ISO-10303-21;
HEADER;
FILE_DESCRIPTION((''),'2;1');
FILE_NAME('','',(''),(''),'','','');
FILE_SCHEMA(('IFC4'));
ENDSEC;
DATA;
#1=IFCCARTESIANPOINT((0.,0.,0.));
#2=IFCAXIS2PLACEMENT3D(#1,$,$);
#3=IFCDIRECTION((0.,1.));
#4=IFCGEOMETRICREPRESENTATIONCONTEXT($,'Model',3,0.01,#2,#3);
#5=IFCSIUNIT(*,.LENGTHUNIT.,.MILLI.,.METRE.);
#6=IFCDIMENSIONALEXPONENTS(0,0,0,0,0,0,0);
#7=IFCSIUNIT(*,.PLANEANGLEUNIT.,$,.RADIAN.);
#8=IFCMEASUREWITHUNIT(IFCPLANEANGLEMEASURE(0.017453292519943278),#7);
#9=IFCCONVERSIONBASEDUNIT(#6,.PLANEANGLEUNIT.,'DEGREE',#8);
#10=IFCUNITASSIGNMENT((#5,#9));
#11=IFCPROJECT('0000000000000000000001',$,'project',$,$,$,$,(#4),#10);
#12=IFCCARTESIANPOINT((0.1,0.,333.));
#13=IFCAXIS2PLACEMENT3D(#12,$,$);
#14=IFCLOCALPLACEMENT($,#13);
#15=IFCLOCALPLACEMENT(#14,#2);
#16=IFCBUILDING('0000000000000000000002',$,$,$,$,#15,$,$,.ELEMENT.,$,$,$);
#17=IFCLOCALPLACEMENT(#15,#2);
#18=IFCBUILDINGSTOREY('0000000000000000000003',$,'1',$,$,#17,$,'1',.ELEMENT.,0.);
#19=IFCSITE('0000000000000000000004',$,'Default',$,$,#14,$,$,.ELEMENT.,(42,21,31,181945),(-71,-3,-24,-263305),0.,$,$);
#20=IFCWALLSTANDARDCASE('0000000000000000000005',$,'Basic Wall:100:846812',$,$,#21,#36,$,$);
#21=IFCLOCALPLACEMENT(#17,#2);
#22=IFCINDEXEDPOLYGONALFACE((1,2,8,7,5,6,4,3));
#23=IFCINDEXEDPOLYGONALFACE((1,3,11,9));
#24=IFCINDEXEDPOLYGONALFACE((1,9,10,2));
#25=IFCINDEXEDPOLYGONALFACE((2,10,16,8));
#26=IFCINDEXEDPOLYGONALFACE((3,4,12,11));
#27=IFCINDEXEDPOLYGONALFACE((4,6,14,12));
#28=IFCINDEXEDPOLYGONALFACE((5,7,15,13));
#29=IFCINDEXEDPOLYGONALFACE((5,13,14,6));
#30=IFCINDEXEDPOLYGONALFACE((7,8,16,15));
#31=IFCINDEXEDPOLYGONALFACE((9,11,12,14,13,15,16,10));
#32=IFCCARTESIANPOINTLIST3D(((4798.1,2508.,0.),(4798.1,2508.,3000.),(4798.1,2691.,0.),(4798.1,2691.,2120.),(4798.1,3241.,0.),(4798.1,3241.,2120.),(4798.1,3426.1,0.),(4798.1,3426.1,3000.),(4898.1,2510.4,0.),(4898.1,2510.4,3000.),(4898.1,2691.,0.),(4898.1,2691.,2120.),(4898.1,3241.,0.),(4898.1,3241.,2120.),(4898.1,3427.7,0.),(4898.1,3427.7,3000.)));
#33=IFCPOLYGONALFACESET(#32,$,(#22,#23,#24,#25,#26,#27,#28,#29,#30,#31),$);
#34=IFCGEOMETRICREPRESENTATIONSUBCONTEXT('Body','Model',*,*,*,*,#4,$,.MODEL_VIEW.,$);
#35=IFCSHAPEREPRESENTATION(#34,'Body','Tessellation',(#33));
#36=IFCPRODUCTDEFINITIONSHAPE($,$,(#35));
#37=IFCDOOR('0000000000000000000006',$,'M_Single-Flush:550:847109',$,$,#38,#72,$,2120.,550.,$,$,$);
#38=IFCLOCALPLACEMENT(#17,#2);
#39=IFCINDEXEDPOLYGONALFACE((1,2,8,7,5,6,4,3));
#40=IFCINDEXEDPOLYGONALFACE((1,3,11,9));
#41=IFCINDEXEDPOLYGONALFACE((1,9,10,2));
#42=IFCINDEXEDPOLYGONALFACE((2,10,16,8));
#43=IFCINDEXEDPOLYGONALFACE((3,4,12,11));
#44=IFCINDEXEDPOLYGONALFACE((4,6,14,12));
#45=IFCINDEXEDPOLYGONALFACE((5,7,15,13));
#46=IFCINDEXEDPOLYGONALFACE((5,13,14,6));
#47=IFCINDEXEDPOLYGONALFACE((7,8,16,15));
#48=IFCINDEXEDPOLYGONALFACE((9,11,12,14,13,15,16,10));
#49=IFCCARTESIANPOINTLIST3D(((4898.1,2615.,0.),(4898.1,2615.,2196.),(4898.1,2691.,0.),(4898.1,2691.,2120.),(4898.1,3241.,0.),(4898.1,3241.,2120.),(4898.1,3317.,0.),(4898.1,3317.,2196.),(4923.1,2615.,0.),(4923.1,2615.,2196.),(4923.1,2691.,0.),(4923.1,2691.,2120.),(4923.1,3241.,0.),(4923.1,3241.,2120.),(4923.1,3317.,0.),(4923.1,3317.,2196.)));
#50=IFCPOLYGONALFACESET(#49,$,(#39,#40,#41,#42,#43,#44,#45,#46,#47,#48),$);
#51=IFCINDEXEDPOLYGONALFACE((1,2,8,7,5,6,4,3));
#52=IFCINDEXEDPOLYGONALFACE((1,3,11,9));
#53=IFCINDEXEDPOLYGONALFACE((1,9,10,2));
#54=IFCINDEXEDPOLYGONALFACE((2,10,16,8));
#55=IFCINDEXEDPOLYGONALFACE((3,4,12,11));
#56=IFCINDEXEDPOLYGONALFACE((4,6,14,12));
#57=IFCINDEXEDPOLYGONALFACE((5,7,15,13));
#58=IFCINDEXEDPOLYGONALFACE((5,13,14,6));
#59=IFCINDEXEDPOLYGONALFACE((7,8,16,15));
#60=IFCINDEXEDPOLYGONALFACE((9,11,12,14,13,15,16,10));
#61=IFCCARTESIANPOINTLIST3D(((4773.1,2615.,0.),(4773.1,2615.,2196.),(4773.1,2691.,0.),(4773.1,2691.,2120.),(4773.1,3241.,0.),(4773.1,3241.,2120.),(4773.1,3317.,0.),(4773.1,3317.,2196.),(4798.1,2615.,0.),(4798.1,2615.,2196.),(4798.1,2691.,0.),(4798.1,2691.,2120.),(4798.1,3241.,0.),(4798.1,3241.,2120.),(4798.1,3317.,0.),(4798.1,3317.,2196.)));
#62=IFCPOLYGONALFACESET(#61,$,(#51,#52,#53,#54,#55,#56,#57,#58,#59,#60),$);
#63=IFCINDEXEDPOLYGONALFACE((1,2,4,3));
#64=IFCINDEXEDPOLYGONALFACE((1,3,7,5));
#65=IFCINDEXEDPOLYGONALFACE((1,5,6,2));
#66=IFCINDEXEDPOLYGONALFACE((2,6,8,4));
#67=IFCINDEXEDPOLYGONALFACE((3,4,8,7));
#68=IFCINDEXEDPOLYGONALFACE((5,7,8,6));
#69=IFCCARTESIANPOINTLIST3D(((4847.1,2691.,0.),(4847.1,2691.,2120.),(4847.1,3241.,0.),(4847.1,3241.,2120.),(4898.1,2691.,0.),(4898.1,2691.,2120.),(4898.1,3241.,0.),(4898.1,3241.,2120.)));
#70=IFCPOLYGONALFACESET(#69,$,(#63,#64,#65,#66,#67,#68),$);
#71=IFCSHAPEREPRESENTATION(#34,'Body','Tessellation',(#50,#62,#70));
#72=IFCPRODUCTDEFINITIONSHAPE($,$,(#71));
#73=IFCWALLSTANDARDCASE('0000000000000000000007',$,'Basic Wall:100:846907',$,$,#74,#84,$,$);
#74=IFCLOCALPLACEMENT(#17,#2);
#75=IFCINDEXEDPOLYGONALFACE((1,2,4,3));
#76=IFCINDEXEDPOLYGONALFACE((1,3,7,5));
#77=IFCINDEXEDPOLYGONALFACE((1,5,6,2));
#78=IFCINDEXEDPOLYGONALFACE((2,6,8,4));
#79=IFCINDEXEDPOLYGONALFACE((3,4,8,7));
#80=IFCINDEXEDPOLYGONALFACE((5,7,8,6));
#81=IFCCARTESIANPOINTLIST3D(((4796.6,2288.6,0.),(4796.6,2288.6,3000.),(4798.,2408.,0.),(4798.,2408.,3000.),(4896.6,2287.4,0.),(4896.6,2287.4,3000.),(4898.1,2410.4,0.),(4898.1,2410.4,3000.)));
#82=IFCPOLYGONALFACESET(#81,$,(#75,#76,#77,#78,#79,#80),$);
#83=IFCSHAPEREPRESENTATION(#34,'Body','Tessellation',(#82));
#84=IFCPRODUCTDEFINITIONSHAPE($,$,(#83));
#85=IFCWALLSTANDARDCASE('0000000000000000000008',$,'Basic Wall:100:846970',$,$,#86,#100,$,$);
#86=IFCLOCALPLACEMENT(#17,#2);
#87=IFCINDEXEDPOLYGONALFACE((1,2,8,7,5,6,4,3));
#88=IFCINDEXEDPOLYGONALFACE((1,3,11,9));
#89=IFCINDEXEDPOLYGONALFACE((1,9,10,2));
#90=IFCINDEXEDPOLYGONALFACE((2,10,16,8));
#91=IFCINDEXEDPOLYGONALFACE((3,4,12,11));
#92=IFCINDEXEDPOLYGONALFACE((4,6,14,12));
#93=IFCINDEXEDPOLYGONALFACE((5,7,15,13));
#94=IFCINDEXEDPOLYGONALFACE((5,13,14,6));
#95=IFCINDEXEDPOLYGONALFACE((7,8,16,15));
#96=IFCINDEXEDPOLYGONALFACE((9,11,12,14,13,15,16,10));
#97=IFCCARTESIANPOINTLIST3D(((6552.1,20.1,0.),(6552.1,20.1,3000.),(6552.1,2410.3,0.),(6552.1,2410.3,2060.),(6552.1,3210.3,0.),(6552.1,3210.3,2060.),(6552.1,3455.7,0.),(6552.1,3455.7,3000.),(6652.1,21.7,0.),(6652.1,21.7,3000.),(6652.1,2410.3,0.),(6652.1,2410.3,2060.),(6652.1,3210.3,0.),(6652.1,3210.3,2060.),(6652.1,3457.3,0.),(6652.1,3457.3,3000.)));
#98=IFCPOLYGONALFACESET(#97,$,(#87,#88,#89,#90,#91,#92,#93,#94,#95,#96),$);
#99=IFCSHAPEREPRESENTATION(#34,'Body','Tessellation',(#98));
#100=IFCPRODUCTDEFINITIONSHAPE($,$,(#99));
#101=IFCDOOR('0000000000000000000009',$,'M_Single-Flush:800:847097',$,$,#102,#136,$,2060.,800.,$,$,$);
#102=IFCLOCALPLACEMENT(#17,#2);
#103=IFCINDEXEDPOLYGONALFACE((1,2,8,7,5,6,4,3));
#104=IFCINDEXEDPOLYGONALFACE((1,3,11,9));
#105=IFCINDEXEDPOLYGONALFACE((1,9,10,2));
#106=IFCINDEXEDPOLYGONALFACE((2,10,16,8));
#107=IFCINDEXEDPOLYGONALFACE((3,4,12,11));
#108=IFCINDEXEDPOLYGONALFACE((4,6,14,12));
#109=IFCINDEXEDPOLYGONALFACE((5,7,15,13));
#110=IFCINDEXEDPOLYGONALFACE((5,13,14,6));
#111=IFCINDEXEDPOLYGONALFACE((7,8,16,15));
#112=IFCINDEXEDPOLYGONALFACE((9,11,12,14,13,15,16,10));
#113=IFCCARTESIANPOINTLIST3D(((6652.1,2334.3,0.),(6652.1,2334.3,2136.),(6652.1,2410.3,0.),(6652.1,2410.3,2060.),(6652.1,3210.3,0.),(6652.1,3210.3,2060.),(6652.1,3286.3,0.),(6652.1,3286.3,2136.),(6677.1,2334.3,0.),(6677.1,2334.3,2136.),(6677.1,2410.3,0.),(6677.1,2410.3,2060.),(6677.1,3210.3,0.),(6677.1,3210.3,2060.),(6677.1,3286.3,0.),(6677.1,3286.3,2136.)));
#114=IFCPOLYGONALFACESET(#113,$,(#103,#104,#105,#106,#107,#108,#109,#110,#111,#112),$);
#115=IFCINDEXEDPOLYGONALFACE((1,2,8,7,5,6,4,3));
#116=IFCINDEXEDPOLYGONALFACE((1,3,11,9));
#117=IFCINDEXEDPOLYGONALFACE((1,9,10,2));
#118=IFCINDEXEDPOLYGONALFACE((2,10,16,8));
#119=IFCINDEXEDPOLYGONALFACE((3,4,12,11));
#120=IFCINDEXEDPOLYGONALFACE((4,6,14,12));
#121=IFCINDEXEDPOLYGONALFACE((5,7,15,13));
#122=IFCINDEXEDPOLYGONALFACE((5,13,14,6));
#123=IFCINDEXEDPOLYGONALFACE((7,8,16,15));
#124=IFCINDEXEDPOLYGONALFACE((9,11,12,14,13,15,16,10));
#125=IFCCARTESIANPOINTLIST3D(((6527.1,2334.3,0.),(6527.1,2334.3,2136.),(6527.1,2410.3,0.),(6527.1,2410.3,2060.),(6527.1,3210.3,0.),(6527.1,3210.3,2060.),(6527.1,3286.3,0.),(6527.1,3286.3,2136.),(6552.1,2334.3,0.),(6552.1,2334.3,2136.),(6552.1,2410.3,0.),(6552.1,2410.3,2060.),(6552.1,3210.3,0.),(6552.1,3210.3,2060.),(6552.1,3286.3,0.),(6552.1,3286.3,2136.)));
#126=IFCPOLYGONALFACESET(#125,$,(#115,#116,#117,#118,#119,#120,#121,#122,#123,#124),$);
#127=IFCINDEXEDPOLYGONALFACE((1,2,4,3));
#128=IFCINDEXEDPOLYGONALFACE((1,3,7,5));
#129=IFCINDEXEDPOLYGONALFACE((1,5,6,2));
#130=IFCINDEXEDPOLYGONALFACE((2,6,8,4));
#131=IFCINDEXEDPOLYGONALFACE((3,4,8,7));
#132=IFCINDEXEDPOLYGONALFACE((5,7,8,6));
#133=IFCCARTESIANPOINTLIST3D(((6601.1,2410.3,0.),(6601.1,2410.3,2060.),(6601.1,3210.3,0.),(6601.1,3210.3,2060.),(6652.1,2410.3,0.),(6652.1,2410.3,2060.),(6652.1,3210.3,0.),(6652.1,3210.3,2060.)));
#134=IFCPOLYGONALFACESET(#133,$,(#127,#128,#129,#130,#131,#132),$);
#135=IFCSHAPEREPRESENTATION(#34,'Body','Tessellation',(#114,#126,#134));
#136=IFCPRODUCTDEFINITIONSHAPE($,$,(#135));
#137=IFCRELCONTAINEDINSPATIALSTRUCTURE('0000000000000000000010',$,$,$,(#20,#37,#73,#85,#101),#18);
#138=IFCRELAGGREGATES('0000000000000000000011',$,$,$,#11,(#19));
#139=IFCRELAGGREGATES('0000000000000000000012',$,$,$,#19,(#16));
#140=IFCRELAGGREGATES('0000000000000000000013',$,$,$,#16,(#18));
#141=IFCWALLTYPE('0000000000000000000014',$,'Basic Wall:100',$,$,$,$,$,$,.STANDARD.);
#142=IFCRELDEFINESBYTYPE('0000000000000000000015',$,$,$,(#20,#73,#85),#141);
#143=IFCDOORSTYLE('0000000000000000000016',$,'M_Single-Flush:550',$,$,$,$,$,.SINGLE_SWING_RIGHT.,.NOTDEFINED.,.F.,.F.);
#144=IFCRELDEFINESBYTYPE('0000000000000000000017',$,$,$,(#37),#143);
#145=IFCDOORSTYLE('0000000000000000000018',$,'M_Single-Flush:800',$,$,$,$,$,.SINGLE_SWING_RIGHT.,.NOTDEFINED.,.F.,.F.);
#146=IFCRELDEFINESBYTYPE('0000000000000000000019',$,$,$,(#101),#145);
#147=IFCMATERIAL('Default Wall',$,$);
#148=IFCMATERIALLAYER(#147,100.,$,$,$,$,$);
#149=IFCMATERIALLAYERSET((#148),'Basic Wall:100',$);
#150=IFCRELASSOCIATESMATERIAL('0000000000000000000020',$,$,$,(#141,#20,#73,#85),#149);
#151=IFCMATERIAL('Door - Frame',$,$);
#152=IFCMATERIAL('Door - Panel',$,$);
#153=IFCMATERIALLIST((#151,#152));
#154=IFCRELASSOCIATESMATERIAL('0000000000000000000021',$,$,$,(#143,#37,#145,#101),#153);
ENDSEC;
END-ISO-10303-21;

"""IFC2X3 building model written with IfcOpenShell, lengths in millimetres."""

from ifc_helpers import new_model, entity, si_unit, converted_unit, direction, frame, frame_2d, origin, origin_2d_with_axis, place, context, subcontext, project, spatial, polyline, rectangle, outline, extrude, source, transform, mapped, material, material_list, layer, layer_set, layer_usage, type_object, type_shapes, element, fill, save


model = new_model("IFC2X3")

# Units and contexts
model_context = context("Model", 3, precision=0.01, world=origin(), true_north=direction((0.0, 1.0)))
body_context = subcontext(model_context, "Body", "Model", "MODEL_VIEW")
ifc_project = project(units=[si_unit("LENGTHUNIT", "METRE", prefix="MILLI"), converted_unit("PLANEANGLEUNIT", "DEGREE", entity("IfcPlaneAngleMeasure", 0.017453292519943278), si_unit("PLANEANGLEUNIT", "RADIAN"), dimensions=[0, 0, 0, 0, 0, 0, 0])], contexts=[model_context])

# Site, building, storey
site_placement = place(None, frame((0.1, 0.0, 333.0)))
site = spatial("IfcSite", under=ifc_project, at=site_placement, Name="Default", CompositionType="ELEMENT", RefLatitude=(42, 21, 31, 181945), RefLongitude=(-71, -3, -24, -263305), RefElevation=0.0)
building_placement = place(site_placement, origin())
building = spatial("IfcBuilding", under=site, at=building_placement, CompositionType="ELEMENT")
storey_placement = place(building_placement, origin())
storey = spatial("IfcBuildingStorey", under=building, at=storey_placement, Name="1", LongName="1", CompositionType="ELEMENT", Elevation=0.0)

# Shared definitions
ifc_material_1 = material(Name="Default Wall")

# Shared definitions
ifc_material_2 = material(Name="Door - Frame")
ifc_material_3 = material(Name="Door - Panel")
ifc_material_list_1 = material_list([ifc_material_2, ifc_material_3])

# Wall, opening, door
ifc_layer_1 = layer(ifc_material_1, 100.0)
ifc_layer_set_1 = layer_set([ifc_layer_1], Name="Basic Wall:100")
ifc_layer_usage_1 = layer_usage(ifc_layer_set_1, "AXIS2", "NEGATIVE", 50.0)
wall_type_1 = type_object("IfcWallType", Name="Basic Wall:100", PredefinedType="STANDARD", material=ifc_layer_set_1)
wall_1_placement = place(storey_placement, frame((4848.1, 2508.0, 0.0), z_axis=(0.0, 0.0, 1.0), x_axis=(0.0, 1.0, 0.0)))
wall_1 = element("IfcWallStandardCase", 1, at=wall_1_placement, inside=storey, type_object=wall_type_1, material=ifc_layer_usage_1, Name="Basic Wall:100:846812", context=body_context, shape_type="SweptSolid", body=[
    extrude(outline(polyline([(2.3, -50.0), (919.7, -50.0), (918.0, 50.0), (0.0, 50.0), (2.3, -50.0)])), origin(), (0.0, 0.0, 1.0), 3000.0),
])
opening_1_placement = place(wall_1_placement, frame((732.9, 50.0, 0.0)))
opening_1 = element("IfcOpeningElement", 2, at=opening_1_placement, cuts=wall_1, ObjectType="Opening", context=body_context, shape_type="SweptSolid", body=[
    extrude(rectangle(XDim=550.0, YDim=2120.0, at=frame_2d((1060.0, 275.0), x_axis=(0.0, 1.0))), frame((0.0, 0.0, 0.0), z_axis=(0.0, -1.0, 0.0), x_axis=(0.0, 0.0, 1.0)), (0.0, 0.0, 1.0), 100.0),
])
door_style_1 = type_object("IfcDoorStyle", Name="M_Single-Flush:550", ConstructionType="NOTDEFINED", OperationType="SINGLE_SWING_RIGHT", ParameterTakesPrecedence=False, Sizeable=False, material=ifc_material_list_1)
shared_shape_1 = source(origin(), body_context, "Body", "SweptSolid", [
    extrude(outline(polyline([(-351.0, -1117.0), (351.0, -1117.0), (351.0, 1079.0), (275.0, 1079.0), (275.0, -1041.0), (-275.0, -1041.0), (-275.0, 1079.0), (-351.0, 1079.0), (-351.0, -1117.0)])), frame((275.0, 100.0, 1079.0), z_axis=(0.0, 1.0, 0.0), x_axis=(1.0, 0.0, 0.0)), (0.0, 0.0, 1.0), 25.0),
    extrude(outline(polyline([(-1117.0, -351.0), (1079.0, -351.0), (1079.0, -275.0), (-1041.0, -275.0), (-1041.0, 275.0), (1079.0, 275.0), (1079.0, 351.0), (-1117.0, 351.0), (-1117.0, -351.0)])), frame((275.0, -25.0, 1079.0), z_axis=(0.0, 1.0, 0.0), x_axis=(0.0, 0.0, -1.0)), (0.0, 0.0, 1.0), 25.0),
    extrude(rectangle(XDim=51.0, YDim=550.0, at=origin_2d_with_axis()), frame((275.0, 74.5, 0.0), z_axis=(0.0, 0.0, 1.0), x_axis=(0.0, 1.0, 0.0)), (0.0, 0.0, 1.0), 2120.0),
])
type_shapes(door_style_1, [shared_shape_1])
door_1_placement = place(opening_1_placement, frame((0.0, 0.0, 0.0), z_axis=(0.0, 0.0, 1.0), x_axis=(-1.0, 0.0, 0.0)))
door_1 = element("IfcDoor", 3, at=door_1_placement, inside=storey, type_object=door_style_1, material=ifc_material_list_1, Name="M_Single-Flush:550:847109", OverallHeight=2120.0, OverallWidth=550.0, context=body_context, shape_type="MappedRepresentation", body=[
    mapped(shared_shape_1, transform((0.0, 0.0, 0.0), scale=1.0)),
])
fill(opening_1, door_1)

# Wall
ifc_layer_usage_2 = layer_usage(ifc_layer_set_1, "AXIS2", "POSITIVE", -50.0)
wall_2_placement = place(storey_placement, frame((4848.1, 2411.0, 0.0), z_axis=(0.0, 0.0, 1.0), x_axis=(-0.011924, -0.999929, 0.0)))
element("IfcWallStandardCase", 4, at=wall_2_placement, inside=storey, type_object=wall_type_1, material=ifc_layer_usage_2, Name="Basic Wall:100:846907", context=body_context, shape_type="SweptSolid", body=[
    extrude(outline(polyline([(122.9, -50.0), (122.9, 50.0), (0.0, 50.0), (3.5, -50.0), (122.9, -50.0)])), origin(), (0.0, 0.0, 1.0), 3000.0),
])

# Wall, opening, door
ifc_layer_usage_3 = layer_usage(ifc_layer_set_1, "AXIS2", "POSITIVE", -50.0)
wall_3_placement = place(storey_placement, frame((6602.1, 3457.3, 0.0), z_axis=(0.0, 0.0, 1.0), x_axis=(0.0, -1.0, 0.0)))
wall_3 = element("IfcWallStandardCase", 5, at=wall_3_placement, inside=storey, type_object=wall_type_1, material=ifc_layer_usage_3, Name="Basic Wall:100:846970", context=body_context, shape_type="SweptSolid", body=[
    extrude(outline(polyline([(1.7, -50.0), (1899.0, -50.0), (1999.0, -50.0), (3437.2, -50.0), (3435.7, 50.0), (3036.9, 50.0), (2936.9, 50.0), (0.0, 50.0), (1.7, -50.0)])), origin(), (0.0, 0.0, 1.0), 3000.0),
])
opening_2_placement = place(wall_3_placement, frame((247.0, -50.0, 0.0)))
opening_2 = element("IfcOpeningElement", 6, at=opening_2_placement, cuts=wall_3, ObjectType="Opening", context=body_context, shape_type="SweptSolid", body=[
    extrude(rectangle(XDim=800.0, YDim=2060.0, at=frame_2d((1030.0, 400.0), x_axis=(0.0, 1.0))), frame((0.0, 0.0, 0.0), z_axis=(0.0, 1.0, 0.0), x_axis=(0.0, 0.0, 1.0)), (0.0, 0.0, 1.0), 100.0),
])
door_style_2 = type_object("IfcDoorStyle", Name="M_Single-Flush:800", ConstructionType="NOTDEFINED", OperationType="SINGLE_SWING_RIGHT", ParameterTakesPrecedence=False, Sizeable=False, material=ifc_material_list_1)
shared_shape_2 = source(origin(), body_context, "Body", "SweptSolid", [
    extrude(outline(polyline([(-476.0, -1087.0), (476.0, -1087.0), (476.0, 1049.0), (400.0, 1049.0), (400.0, -1011.0), (-400.0, -1011.0), (-400.0, 1049.0), (-476.0, 1049.0), (-476.0, -1087.0)])), frame((400.0, 100.0, 1049.0), z_axis=(0.0, 1.0, 0.0), x_axis=(1.0, 0.0, 0.0)), (0.0, 0.0, 1.0), 25.0),
    extrude(outline(polyline([(-1087.0, -476.0), (1049.0, -476.0), (1049.0, -400.0), (-1011.0, -400.0), (-1011.0, 400.0), (1049.0, 400.0), (1049.0, 476.0), (-1087.0, 476.0), (-1087.0, -476.0)])), frame((400.0, -25.0, 1049.0), z_axis=(0.0, 1.0, 0.0), x_axis=(0.0, 0.0, -1.0)), (0.0, 0.0, 1.0), 25.0),
    extrude(rectangle(XDim=51.0, YDim=800.0, at=origin_2d_with_axis()), frame((400.0, 74.5, 0.0), z_axis=(0.0, 0.0, 1.0), x_axis=(0.0, 1.0, 0.0)), (0.0, 0.0, 1.0), 2060.0),
])
type_shapes(door_style_2, [shared_shape_2])
door_2_placement = place(opening_2_placement, origin())
door_2 = element("IfcDoor", 7, at=door_2_placement, inside=storey, type_object=door_style_2, material=ifc_material_list_1, Name="M_Single-Flush:800:847097", OverallHeight=2060.0, OverallWidth=800.0, context=body_context, shape_type="MappedRepresentation", body=[
    mapped(shared_shape_2, transform((0.0, 0.0, 0.0), scale=1.0)),
])
fill(opening_2, door_2)

save(model, "model.ifc")
